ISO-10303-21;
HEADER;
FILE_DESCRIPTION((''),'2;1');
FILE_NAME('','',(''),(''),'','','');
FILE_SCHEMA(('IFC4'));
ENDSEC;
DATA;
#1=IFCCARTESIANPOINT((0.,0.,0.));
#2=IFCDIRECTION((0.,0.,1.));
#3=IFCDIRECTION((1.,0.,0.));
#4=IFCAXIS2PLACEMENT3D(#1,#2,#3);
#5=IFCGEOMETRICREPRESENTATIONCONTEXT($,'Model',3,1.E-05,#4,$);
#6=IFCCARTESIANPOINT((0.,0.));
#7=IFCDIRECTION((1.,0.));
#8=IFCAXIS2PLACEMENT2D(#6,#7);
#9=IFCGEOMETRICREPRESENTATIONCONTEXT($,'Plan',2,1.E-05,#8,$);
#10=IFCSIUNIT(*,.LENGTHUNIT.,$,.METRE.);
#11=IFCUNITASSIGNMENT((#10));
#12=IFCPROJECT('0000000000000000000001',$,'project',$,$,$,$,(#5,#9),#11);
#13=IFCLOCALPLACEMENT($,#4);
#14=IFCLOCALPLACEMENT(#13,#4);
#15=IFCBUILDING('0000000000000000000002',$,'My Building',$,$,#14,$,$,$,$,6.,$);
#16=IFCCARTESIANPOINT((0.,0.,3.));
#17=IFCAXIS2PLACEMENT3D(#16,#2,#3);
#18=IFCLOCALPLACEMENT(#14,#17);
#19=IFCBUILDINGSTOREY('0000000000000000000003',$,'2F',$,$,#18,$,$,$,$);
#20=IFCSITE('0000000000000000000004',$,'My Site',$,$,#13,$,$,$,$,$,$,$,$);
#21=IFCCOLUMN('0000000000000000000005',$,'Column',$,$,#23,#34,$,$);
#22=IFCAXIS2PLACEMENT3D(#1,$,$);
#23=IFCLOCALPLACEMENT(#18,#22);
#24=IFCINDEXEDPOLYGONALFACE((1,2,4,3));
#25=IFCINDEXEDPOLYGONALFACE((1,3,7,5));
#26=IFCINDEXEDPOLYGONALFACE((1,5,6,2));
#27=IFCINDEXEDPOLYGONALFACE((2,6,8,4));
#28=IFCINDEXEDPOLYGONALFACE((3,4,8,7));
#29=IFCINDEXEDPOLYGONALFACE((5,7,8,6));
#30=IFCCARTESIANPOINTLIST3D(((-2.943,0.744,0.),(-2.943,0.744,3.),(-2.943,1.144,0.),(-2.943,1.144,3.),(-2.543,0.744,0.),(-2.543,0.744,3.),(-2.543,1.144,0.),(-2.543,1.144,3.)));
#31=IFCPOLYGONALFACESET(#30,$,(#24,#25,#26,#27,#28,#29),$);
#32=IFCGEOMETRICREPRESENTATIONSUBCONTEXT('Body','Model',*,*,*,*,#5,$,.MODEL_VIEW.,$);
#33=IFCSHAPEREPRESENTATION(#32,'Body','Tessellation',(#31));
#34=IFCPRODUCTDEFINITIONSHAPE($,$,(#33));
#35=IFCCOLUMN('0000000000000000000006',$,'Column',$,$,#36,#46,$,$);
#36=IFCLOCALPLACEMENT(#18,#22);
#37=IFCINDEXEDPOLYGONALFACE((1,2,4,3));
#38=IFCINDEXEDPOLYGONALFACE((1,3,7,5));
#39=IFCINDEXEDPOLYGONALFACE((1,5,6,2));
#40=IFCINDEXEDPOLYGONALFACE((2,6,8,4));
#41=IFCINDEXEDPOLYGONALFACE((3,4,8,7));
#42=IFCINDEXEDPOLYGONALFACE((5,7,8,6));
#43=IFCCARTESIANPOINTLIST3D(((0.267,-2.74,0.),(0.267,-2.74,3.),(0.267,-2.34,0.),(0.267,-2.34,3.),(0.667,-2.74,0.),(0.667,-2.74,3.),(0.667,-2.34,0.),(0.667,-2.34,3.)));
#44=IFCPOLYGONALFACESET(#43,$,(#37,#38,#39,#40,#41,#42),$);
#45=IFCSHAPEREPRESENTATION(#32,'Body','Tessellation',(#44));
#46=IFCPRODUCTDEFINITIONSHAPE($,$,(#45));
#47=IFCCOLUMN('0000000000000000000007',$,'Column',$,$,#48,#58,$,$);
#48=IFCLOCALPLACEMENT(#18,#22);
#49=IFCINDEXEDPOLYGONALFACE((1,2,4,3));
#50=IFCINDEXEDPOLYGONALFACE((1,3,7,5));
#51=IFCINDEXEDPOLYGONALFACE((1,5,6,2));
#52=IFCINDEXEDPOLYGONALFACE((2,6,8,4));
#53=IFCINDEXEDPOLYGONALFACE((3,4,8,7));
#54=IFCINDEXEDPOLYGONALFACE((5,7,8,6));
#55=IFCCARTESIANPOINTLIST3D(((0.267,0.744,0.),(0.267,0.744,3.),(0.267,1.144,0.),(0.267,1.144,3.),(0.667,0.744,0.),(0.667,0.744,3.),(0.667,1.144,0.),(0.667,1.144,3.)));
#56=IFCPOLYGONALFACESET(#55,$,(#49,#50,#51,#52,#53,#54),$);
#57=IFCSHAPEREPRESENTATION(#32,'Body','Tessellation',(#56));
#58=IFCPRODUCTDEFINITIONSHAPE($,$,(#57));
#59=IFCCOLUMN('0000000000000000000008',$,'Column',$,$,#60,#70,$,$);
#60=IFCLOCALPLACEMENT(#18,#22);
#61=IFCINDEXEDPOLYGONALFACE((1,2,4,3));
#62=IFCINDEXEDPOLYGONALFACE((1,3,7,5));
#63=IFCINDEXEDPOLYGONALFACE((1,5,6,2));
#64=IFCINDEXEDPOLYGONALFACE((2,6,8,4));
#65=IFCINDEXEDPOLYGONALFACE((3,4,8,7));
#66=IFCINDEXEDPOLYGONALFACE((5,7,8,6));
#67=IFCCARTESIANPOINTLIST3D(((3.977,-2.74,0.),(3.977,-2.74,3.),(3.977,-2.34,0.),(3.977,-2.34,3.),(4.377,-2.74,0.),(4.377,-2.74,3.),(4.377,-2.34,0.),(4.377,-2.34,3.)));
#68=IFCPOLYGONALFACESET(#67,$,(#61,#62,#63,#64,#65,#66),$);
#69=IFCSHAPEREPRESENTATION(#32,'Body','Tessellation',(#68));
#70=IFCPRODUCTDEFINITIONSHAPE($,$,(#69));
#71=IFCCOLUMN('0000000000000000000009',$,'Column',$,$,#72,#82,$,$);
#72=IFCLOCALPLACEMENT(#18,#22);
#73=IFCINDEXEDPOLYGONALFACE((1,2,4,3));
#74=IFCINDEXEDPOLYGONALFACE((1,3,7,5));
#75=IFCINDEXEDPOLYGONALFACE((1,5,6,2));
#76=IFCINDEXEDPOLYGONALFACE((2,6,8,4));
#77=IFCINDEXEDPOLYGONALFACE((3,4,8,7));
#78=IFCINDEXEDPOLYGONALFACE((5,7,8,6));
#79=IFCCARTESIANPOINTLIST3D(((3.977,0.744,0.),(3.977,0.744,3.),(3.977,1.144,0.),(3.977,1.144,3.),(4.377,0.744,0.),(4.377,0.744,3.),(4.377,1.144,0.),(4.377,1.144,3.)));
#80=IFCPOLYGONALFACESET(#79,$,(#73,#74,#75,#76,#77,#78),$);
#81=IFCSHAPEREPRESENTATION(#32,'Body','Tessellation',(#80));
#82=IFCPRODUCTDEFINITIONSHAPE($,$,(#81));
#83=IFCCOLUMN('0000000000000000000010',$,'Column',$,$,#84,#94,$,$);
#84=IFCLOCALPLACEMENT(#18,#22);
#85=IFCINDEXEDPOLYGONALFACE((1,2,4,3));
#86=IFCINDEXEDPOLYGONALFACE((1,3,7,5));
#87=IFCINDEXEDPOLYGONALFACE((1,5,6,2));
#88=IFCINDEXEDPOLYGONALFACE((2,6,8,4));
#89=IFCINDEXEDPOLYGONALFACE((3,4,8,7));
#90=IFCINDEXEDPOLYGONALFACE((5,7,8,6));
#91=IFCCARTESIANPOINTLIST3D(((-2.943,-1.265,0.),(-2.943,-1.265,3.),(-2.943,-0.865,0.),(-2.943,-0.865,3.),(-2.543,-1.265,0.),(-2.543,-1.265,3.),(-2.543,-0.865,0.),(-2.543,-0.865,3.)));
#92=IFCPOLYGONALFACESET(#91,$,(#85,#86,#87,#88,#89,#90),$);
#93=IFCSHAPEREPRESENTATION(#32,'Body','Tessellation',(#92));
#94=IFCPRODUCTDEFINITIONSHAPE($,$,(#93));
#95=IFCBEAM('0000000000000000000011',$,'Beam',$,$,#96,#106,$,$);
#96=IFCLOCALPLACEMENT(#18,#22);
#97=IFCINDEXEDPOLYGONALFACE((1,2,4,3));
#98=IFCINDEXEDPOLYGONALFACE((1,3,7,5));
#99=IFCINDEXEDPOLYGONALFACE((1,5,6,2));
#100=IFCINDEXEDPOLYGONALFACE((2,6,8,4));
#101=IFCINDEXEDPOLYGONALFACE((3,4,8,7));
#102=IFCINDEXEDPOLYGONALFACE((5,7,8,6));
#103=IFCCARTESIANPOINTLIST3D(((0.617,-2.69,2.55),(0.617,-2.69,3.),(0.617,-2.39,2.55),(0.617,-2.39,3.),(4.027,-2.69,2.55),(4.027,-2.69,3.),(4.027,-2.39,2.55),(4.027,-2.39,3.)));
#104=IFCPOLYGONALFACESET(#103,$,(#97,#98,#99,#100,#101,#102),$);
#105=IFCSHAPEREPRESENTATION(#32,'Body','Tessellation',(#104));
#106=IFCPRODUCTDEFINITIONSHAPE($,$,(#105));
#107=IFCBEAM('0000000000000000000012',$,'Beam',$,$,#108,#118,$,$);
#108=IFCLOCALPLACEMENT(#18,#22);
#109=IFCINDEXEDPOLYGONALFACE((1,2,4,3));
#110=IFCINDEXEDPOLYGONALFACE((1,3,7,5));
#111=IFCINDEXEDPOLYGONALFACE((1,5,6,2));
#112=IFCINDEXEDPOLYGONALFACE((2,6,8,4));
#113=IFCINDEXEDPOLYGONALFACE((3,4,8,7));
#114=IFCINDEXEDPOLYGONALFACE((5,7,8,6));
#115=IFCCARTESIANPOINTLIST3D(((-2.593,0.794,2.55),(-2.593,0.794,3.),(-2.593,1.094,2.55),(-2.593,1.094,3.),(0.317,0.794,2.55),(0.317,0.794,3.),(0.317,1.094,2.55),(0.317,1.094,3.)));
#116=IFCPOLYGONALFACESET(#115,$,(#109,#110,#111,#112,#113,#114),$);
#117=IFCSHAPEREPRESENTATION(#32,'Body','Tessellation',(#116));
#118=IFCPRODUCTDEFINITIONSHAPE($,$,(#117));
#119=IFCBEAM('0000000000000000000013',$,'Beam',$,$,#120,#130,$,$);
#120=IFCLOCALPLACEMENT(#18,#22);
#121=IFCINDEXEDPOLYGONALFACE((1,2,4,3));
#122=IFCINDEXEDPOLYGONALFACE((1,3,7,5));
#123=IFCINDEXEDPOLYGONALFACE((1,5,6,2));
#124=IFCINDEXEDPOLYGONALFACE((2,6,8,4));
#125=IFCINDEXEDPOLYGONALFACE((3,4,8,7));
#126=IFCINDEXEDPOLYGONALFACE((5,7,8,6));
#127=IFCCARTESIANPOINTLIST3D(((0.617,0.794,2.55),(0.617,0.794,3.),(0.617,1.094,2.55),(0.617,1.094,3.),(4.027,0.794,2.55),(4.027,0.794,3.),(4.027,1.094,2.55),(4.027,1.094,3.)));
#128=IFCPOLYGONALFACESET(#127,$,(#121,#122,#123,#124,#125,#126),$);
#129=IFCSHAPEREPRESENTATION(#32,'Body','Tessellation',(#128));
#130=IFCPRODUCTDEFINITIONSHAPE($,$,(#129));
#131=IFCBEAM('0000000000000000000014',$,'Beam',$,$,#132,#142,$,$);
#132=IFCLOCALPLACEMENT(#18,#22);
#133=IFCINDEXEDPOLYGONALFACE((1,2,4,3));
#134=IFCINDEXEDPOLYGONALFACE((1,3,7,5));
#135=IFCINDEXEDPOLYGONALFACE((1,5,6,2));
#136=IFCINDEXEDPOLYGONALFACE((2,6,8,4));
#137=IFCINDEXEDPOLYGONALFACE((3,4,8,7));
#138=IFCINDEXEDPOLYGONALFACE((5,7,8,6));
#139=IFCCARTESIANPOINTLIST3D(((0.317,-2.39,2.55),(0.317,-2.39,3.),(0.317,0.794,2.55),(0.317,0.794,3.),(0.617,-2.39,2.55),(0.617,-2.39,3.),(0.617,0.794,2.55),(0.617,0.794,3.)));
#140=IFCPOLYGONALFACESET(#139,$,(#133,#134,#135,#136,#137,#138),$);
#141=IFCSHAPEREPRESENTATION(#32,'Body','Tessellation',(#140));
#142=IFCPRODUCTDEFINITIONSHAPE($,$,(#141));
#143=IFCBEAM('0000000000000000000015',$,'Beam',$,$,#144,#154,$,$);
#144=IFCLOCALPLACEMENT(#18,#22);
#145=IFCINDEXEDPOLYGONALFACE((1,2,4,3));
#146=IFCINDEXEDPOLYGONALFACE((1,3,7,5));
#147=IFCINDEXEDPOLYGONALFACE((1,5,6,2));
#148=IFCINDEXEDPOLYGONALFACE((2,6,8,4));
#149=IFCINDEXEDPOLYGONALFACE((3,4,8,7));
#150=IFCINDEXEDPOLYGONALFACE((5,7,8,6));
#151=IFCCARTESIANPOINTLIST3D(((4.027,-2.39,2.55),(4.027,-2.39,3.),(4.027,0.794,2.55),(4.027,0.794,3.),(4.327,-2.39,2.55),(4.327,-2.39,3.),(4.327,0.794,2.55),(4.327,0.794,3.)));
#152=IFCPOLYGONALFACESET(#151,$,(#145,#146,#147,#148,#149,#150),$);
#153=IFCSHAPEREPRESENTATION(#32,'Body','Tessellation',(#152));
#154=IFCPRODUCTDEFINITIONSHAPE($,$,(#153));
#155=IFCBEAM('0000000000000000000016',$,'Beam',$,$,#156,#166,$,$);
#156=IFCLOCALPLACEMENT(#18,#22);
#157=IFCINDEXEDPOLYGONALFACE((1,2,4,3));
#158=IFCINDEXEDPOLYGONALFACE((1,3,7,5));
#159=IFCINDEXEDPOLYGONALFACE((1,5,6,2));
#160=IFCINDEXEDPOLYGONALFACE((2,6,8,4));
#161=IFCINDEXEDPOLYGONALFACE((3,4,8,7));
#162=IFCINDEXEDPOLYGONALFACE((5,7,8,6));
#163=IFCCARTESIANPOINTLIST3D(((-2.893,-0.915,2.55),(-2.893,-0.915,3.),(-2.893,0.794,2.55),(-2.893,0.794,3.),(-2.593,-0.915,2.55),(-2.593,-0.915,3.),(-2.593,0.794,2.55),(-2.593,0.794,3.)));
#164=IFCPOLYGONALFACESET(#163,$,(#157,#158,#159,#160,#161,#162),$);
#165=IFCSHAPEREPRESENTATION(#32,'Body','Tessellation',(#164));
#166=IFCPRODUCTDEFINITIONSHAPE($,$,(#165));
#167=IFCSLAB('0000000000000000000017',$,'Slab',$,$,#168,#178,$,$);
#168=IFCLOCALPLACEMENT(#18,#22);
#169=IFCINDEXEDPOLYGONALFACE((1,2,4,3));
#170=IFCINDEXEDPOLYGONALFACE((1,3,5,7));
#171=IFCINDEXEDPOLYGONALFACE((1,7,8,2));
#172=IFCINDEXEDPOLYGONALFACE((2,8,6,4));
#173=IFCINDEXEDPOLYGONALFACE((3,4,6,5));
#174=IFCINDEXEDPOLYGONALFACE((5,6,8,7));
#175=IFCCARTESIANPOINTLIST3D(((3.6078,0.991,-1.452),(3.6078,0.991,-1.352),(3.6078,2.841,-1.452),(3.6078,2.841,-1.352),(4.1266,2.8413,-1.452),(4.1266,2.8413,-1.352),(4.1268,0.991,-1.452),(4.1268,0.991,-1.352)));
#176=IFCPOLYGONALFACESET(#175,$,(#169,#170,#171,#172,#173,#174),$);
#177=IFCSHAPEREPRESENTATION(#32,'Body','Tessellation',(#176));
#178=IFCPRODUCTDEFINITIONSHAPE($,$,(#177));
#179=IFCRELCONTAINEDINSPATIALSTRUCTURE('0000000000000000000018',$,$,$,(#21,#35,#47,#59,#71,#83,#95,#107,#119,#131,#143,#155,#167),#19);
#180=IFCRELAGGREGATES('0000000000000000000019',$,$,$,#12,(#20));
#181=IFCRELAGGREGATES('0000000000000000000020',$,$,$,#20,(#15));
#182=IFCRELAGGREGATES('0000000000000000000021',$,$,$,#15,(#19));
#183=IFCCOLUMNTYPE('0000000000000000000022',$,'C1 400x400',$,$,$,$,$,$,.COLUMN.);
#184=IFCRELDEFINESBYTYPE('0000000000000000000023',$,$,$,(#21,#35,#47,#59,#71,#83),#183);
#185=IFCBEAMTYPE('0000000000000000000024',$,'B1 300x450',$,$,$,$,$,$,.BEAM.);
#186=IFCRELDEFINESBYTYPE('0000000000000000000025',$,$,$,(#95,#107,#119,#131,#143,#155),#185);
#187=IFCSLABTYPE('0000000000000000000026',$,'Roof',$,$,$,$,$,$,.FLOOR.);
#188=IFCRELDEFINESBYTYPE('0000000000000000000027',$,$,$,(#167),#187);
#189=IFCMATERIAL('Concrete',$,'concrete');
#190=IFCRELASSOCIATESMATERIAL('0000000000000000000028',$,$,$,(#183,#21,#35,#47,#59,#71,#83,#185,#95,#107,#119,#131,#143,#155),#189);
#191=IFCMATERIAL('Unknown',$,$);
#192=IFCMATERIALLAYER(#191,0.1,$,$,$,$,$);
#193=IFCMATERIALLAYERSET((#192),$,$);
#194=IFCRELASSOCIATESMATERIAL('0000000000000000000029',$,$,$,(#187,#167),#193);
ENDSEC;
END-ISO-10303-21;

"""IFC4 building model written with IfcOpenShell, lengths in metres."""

from ifc_helpers import new_model, si_unit, frame, origin_with_axes, origin_2d_with_axis, place, context, subcontext, project, spatial, indexed_curve, rectangle, outline, extrude, material, layer, layer_set, layer_usage, material_profile, profile_set, profile_usage, type_object, element, save


model = new_model("IFC4")

# Units and contexts
model_context = context("Model", 3, precision=1e-05, world=origin_with_axes())
plan_context = context("Plan", 2, precision=1e-05, world=origin_2d_with_axis())
body_context_1 = subcontext(model_context, "Body", "Model", "MODEL_VIEW")
ifc_project = project(units=[si_unit("LENGTHUNIT", "METRE")], contexts=[model_context, plan_context])

# Site, building, storey
site_placement = place(None, origin_with_axes())
site = spatial("IfcSite", under=ifc_project, at=site_placement, Name="My Site")
building_placement = place(site_placement, origin_with_axes())
building = spatial("IfcBuilding", under=site, at=building_placement, Name="My Building", ElevationOfTerrain=6.0)
storey_placement = place(building_placement, frame((0.0, 0.0, 3.0), z_axis=(0.0, 0.0, 1.0), x_axis=(1.0, 0.0, 0.0)))
storey = spatial("IfcBuildingStorey", under=building, at=storey_placement, Name="2F")

# Columns
ifc_material_1 = material(Name="Concrete", Category="concrete")
ifc_material_profile_1 = material_profile(ifc_material_1, rectangle(XDim=0.4, YDim=0.4))
ifc_profile_set_1 = profile_set([ifc_material_profile_1], Name="C1 400x400")
ifc_profile_usage_1 = profile_usage(ifc_profile_set_1, cardinal=5)
column_type = type_object("IfcColumnType", Name="C1 400x400", PredefinedType="COLUMN", material=ifc_profile_set_1)
column_1_placement = place(storey_placement, frame((-2.743, 0.944, 0.0), z_axis=(0.0, 0.0, 1.0), x_axis=(1.0, 0.0, 0.0)))
element("IfcColumn", 1, at=column_1_placement, inside=storey, type_object=column_type, material=ifc_profile_usage_1, Name="Column", context=body_context_1, shape_type="SweptSolid", body=[
    extrude(rectangle(XDim=0.4, YDim=0.4), origin_with_axes(), (0.0, 0.0, 1.0), 3.0),
])
ifc_profile_usage_2 = profile_usage(ifc_profile_set_1, cardinal=5)
column_2_placement = place(storey_placement, frame((0.467, -2.54, 0.0), z_axis=(0.0, 0.0, 1.0), x_axis=(1.0, 0.0, 0.0)))
element("IfcColumn", 2, at=column_2_placement, inside=storey, type_object=column_type, material=ifc_profile_usage_2, Name="Column", context=body_context_1, shape_type="SweptSolid", body=[
    extrude(rectangle(XDim=0.4, YDim=0.4), origin_with_axes(), (0.0, 0.0, 1.0), 3.0),
])
ifc_profile_usage_3 = profile_usage(ifc_profile_set_1, cardinal=5)
column_3_placement = place(storey_placement, frame((0.467, 0.944, 0.0), z_axis=(0.0, 0.0, 1.0), x_axis=(1.0, 0.0, 0.0)))
element("IfcColumn", 3, at=column_3_placement, inside=storey, type_object=column_type, material=ifc_profile_usage_3, Name="Column", context=body_context_1, shape_type="SweptSolid", body=[
    extrude(rectangle(XDim=0.4, YDim=0.4), origin_with_axes(), (0.0, 0.0, 1.0), 3.0),
])
ifc_profile_usage_4 = profile_usage(ifc_profile_set_1, cardinal=5)
column_4_placement = place(storey_placement, frame((4.177, -2.54, 0.0), z_axis=(0.0, 0.0, 1.0), x_axis=(1.0, 0.0, 0.0)))
element("IfcColumn", 4, at=column_4_placement, inside=storey, type_object=column_type, material=ifc_profile_usage_4, Name="Column", context=body_context_1, shape_type="SweptSolid", body=[
    extrude(rectangle(XDim=0.4, YDim=0.4), origin_with_axes(), (0.0, 0.0, 1.0), 3.0),
])
ifc_profile_usage_5 = profile_usage(ifc_profile_set_1, cardinal=5)
column_5_placement = place(storey_placement, frame((4.177, 0.944, 0.0), z_axis=(0.0, 0.0, 1.0), x_axis=(1.0, 0.0, 0.0)))
element("IfcColumn", 5, at=column_5_placement, inside=storey, type_object=column_type, material=ifc_profile_usage_5, Name="Column", context=body_context_1, shape_type="SweptSolid", body=[
    extrude(rectangle(XDim=0.4, YDim=0.4), origin_with_axes(), (0.0, 0.0, 1.0), 3.0),
])
ifc_profile_usage_6 = profile_usage(ifc_profile_set_1, cardinal=5)
column_6_placement = place(storey_placement, frame((-2.743, -1.065, 0.0), z_axis=(0.0, 0.0, 1.0), x_axis=(1.0, 0.0, 0.0)))
element("IfcColumn", 6, at=column_6_placement, inside=storey, type_object=column_type, material=ifc_profile_usage_6, Name="Column", context=body_context_1, shape_type="SweptSolid", body=[
    extrude(rectangle(XDim=0.4, YDim=0.4), origin_with_axes(), (0.0, 0.0, 1.0), 3.0),
])

# Beams
ifc_material_profile_2 = material_profile(ifc_material_1, rectangle(XDim=0.3, YDim=0.45))
ifc_profile_set_2 = profile_set([ifc_material_profile_2], Name="B1 300x450")
ifc_profile_usage_7 = profile_usage(ifc_profile_set_2, cardinal=8)
beam_type = type_object("IfcBeamType", Name="B1 300x450", PredefinedType="BEAM", material=ifc_profile_set_2)
beam_1_placement = place(storey_placement, frame((0.617, -2.54, 2.975), z_axis=(1.0, 0.0, 0.0), x_axis=(0.0, 1.0, 0.0)))
element("IfcBeam", 7, at=beam_1_placement, inside=storey, type_object=beam_type, material=ifc_profile_usage_7, Name="Beam", context=body_context_1, shape_type="SweptSolid", body=[
    extrude(rectangle(XDim=0.3, YDim=0.45), frame((0.0, -0.2, 0.0), z_axis=(0.0, 0.0, 1.0), x_axis=(1.0, 0.0, 0.0)), (0.0, 0.0, 1.0), 3.41),
])
ifc_profile_usage_8 = profile_usage(ifc_profile_set_2, cardinal=8)
beam_2_placement = place(storey_placement, frame((-2.593, 0.944, 2.975), z_axis=(1.0, 0.0, 0.0), x_axis=(0.0, 1.0, 0.0)))
element("IfcBeam", 8, at=beam_2_placement, inside=storey, type_object=beam_type, material=ifc_profile_usage_8, Name="Beam", context=body_context_1, shape_type="SweptSolid", body=[
    extrude(rectangle(XDim=0.3, YDim=0.45), frame((0.0, -0.2, 0.0), z_axis=(0.0, 0.0, 1.0), x_axis=(1.0, 0.0, 0.0)), (0.0, 0.0, 1.0), 2.91),
])
ifc_profile_usage_9 = profile_usage(ifc_profile_set_2, cardinal=8)
beam_3_placement = place(storey_placement, frame((0.617, 0.944, 2.975), z_axis=(1.0, 0.0, 0.0), x_axis=(0.0, 1.0, 0.0)))
element("IfcBeam", 9, at=beam_3_placement, inside=storey, type_object=beam_type, material=ifc_profile_usage_9, Name="Beam", context=body_context_1, shape_type="SweptSolid", body=[
    extrude(rectangle(XDim=0.3, YDim=0.45), frame((0.0, -0.2, 0.0), z_axis=(0.0, 0.0, 1.0), x_axis=(1.0, 0.0, 0.0)), (0.0, 0.0, 1.0), 3.41),
])
ifc_profile_usage_10 = profile_usage(ifc_profile_set_2, cardinal=8)
beam_4_placement = place(storey_placement, frame((0.467, -2.39, 2.975), z_axis=(0.0, 1.0, 0.0), x_axis=(-1.0, 0.0, 0.0)))
element("IfcBeam", 10, at=beam_4_placement, inside=storey, type_object=beam_type, material=ifc_profile_usage_10, Name="Beam", context=body_context_1, shape_type="SweptSolid", body=[
    extrude(rectangle(XDim=0.3, YDim=0.45), frame((0.0, -0.2, 0.0), z_axis=(0.0, 0.0, 1.0), x_axis=(1.0, 0.0, 0.0)), (0.0, 0.0, 1.0), 3.184),
])
ifc_profile_usage_11 = profile_usage(ifc_profile_set_2, cardinal=8)
beam_5_placement = place(storey_placement, frame((4.177, -2.39, 2.975), z_axis=(0.0, 1.0, 0.0), x_axis=(-1.0, 0.0, 0.0)))
element("IfcBeam", 11, at=beam_5_placement, inside=storey, type_object=beam_type, material=ifc_profile_usage_11, Name="Beam", context=body_context_1, shape_type="SweptSolid", body=[
    extrude(rectangle(XDim=0.3, YDim=0.45), frame((0.0, -0.2, 0.0), z_axis=(0.0, 0.0, 1.0), x_axis=(1.0, 0.0, 0.0)), (0.0, 0.0, 1.0), 3.184),
])
ifc_profile_usage_12 = profile_usage(ifc_profile_set_2, cardinal=8)
beam_6_placement = place(storey_placement, frame((-2.743, -0.915, 2.975), z_axis=(0.0, 1.0, 0.0), x_axis=(-1.0, 0.0, 0.0)))
element("IfcBeam", 12, at=beam_6_placement, inside=storey, type_object=beam_type, material=ifc_profile_usage_12, Name="Beam", context=body_context_1, shape_type="SweptSolid", body=[
    extrude(rectangle(XDim=0.3, YDim=0.45), frame((0.0, -0.2, 0.0), z_axis=(0.0, 0.0, 1.0), x_axis=(1.0, 0.0, 0.0)), (0.0, 0.0, 1.0), 1.709),
])

# Slab
ifc_material_2 = material(Name="Unknown")
ifc_layer_1 = layer(ifc_material_2, 0.1)
ifc_layer_set_1 = layer_set([ifc_layer_1])
ifc_layer_usage_1 = layer_usage(ifc_layer_set_1, "AXIS3", "POSITIVE", -0.1)
slab_type = type_object("IfcSlabType", Name="Roof", PredefinedType="FLOOR", material=ifc_layer_set_1)
slab_placement = place(storey_placement, frame((4.1268, 0.991, -1.352), z_axis=(0.0, 0.0, 1.0), x_axis=(1.0, 0.0, 0.0)))
element("IfcSlab", 13, at=slab_placement, inside=storey, type_object=slab_type, material=ifc_layer_usage_1, Name="Slab", context=body_context_1, shape_type="SweptSolid", body=[
    extrude(outline(indexed_curve([(0.0, 0.0), (-0.519, 0.0), (-0.519, 1.85), (-0.0002, 1.8503), (0.0, 0.0)])), frame((0.0, 0.0, -0.1), z_axis=(0.0, 0.0, 1.0), x_axis=(1.0, 0.0, 0.0)), (0.0, 0.0, 1.0), 0.1),
])

save(model, "model.ifc")
